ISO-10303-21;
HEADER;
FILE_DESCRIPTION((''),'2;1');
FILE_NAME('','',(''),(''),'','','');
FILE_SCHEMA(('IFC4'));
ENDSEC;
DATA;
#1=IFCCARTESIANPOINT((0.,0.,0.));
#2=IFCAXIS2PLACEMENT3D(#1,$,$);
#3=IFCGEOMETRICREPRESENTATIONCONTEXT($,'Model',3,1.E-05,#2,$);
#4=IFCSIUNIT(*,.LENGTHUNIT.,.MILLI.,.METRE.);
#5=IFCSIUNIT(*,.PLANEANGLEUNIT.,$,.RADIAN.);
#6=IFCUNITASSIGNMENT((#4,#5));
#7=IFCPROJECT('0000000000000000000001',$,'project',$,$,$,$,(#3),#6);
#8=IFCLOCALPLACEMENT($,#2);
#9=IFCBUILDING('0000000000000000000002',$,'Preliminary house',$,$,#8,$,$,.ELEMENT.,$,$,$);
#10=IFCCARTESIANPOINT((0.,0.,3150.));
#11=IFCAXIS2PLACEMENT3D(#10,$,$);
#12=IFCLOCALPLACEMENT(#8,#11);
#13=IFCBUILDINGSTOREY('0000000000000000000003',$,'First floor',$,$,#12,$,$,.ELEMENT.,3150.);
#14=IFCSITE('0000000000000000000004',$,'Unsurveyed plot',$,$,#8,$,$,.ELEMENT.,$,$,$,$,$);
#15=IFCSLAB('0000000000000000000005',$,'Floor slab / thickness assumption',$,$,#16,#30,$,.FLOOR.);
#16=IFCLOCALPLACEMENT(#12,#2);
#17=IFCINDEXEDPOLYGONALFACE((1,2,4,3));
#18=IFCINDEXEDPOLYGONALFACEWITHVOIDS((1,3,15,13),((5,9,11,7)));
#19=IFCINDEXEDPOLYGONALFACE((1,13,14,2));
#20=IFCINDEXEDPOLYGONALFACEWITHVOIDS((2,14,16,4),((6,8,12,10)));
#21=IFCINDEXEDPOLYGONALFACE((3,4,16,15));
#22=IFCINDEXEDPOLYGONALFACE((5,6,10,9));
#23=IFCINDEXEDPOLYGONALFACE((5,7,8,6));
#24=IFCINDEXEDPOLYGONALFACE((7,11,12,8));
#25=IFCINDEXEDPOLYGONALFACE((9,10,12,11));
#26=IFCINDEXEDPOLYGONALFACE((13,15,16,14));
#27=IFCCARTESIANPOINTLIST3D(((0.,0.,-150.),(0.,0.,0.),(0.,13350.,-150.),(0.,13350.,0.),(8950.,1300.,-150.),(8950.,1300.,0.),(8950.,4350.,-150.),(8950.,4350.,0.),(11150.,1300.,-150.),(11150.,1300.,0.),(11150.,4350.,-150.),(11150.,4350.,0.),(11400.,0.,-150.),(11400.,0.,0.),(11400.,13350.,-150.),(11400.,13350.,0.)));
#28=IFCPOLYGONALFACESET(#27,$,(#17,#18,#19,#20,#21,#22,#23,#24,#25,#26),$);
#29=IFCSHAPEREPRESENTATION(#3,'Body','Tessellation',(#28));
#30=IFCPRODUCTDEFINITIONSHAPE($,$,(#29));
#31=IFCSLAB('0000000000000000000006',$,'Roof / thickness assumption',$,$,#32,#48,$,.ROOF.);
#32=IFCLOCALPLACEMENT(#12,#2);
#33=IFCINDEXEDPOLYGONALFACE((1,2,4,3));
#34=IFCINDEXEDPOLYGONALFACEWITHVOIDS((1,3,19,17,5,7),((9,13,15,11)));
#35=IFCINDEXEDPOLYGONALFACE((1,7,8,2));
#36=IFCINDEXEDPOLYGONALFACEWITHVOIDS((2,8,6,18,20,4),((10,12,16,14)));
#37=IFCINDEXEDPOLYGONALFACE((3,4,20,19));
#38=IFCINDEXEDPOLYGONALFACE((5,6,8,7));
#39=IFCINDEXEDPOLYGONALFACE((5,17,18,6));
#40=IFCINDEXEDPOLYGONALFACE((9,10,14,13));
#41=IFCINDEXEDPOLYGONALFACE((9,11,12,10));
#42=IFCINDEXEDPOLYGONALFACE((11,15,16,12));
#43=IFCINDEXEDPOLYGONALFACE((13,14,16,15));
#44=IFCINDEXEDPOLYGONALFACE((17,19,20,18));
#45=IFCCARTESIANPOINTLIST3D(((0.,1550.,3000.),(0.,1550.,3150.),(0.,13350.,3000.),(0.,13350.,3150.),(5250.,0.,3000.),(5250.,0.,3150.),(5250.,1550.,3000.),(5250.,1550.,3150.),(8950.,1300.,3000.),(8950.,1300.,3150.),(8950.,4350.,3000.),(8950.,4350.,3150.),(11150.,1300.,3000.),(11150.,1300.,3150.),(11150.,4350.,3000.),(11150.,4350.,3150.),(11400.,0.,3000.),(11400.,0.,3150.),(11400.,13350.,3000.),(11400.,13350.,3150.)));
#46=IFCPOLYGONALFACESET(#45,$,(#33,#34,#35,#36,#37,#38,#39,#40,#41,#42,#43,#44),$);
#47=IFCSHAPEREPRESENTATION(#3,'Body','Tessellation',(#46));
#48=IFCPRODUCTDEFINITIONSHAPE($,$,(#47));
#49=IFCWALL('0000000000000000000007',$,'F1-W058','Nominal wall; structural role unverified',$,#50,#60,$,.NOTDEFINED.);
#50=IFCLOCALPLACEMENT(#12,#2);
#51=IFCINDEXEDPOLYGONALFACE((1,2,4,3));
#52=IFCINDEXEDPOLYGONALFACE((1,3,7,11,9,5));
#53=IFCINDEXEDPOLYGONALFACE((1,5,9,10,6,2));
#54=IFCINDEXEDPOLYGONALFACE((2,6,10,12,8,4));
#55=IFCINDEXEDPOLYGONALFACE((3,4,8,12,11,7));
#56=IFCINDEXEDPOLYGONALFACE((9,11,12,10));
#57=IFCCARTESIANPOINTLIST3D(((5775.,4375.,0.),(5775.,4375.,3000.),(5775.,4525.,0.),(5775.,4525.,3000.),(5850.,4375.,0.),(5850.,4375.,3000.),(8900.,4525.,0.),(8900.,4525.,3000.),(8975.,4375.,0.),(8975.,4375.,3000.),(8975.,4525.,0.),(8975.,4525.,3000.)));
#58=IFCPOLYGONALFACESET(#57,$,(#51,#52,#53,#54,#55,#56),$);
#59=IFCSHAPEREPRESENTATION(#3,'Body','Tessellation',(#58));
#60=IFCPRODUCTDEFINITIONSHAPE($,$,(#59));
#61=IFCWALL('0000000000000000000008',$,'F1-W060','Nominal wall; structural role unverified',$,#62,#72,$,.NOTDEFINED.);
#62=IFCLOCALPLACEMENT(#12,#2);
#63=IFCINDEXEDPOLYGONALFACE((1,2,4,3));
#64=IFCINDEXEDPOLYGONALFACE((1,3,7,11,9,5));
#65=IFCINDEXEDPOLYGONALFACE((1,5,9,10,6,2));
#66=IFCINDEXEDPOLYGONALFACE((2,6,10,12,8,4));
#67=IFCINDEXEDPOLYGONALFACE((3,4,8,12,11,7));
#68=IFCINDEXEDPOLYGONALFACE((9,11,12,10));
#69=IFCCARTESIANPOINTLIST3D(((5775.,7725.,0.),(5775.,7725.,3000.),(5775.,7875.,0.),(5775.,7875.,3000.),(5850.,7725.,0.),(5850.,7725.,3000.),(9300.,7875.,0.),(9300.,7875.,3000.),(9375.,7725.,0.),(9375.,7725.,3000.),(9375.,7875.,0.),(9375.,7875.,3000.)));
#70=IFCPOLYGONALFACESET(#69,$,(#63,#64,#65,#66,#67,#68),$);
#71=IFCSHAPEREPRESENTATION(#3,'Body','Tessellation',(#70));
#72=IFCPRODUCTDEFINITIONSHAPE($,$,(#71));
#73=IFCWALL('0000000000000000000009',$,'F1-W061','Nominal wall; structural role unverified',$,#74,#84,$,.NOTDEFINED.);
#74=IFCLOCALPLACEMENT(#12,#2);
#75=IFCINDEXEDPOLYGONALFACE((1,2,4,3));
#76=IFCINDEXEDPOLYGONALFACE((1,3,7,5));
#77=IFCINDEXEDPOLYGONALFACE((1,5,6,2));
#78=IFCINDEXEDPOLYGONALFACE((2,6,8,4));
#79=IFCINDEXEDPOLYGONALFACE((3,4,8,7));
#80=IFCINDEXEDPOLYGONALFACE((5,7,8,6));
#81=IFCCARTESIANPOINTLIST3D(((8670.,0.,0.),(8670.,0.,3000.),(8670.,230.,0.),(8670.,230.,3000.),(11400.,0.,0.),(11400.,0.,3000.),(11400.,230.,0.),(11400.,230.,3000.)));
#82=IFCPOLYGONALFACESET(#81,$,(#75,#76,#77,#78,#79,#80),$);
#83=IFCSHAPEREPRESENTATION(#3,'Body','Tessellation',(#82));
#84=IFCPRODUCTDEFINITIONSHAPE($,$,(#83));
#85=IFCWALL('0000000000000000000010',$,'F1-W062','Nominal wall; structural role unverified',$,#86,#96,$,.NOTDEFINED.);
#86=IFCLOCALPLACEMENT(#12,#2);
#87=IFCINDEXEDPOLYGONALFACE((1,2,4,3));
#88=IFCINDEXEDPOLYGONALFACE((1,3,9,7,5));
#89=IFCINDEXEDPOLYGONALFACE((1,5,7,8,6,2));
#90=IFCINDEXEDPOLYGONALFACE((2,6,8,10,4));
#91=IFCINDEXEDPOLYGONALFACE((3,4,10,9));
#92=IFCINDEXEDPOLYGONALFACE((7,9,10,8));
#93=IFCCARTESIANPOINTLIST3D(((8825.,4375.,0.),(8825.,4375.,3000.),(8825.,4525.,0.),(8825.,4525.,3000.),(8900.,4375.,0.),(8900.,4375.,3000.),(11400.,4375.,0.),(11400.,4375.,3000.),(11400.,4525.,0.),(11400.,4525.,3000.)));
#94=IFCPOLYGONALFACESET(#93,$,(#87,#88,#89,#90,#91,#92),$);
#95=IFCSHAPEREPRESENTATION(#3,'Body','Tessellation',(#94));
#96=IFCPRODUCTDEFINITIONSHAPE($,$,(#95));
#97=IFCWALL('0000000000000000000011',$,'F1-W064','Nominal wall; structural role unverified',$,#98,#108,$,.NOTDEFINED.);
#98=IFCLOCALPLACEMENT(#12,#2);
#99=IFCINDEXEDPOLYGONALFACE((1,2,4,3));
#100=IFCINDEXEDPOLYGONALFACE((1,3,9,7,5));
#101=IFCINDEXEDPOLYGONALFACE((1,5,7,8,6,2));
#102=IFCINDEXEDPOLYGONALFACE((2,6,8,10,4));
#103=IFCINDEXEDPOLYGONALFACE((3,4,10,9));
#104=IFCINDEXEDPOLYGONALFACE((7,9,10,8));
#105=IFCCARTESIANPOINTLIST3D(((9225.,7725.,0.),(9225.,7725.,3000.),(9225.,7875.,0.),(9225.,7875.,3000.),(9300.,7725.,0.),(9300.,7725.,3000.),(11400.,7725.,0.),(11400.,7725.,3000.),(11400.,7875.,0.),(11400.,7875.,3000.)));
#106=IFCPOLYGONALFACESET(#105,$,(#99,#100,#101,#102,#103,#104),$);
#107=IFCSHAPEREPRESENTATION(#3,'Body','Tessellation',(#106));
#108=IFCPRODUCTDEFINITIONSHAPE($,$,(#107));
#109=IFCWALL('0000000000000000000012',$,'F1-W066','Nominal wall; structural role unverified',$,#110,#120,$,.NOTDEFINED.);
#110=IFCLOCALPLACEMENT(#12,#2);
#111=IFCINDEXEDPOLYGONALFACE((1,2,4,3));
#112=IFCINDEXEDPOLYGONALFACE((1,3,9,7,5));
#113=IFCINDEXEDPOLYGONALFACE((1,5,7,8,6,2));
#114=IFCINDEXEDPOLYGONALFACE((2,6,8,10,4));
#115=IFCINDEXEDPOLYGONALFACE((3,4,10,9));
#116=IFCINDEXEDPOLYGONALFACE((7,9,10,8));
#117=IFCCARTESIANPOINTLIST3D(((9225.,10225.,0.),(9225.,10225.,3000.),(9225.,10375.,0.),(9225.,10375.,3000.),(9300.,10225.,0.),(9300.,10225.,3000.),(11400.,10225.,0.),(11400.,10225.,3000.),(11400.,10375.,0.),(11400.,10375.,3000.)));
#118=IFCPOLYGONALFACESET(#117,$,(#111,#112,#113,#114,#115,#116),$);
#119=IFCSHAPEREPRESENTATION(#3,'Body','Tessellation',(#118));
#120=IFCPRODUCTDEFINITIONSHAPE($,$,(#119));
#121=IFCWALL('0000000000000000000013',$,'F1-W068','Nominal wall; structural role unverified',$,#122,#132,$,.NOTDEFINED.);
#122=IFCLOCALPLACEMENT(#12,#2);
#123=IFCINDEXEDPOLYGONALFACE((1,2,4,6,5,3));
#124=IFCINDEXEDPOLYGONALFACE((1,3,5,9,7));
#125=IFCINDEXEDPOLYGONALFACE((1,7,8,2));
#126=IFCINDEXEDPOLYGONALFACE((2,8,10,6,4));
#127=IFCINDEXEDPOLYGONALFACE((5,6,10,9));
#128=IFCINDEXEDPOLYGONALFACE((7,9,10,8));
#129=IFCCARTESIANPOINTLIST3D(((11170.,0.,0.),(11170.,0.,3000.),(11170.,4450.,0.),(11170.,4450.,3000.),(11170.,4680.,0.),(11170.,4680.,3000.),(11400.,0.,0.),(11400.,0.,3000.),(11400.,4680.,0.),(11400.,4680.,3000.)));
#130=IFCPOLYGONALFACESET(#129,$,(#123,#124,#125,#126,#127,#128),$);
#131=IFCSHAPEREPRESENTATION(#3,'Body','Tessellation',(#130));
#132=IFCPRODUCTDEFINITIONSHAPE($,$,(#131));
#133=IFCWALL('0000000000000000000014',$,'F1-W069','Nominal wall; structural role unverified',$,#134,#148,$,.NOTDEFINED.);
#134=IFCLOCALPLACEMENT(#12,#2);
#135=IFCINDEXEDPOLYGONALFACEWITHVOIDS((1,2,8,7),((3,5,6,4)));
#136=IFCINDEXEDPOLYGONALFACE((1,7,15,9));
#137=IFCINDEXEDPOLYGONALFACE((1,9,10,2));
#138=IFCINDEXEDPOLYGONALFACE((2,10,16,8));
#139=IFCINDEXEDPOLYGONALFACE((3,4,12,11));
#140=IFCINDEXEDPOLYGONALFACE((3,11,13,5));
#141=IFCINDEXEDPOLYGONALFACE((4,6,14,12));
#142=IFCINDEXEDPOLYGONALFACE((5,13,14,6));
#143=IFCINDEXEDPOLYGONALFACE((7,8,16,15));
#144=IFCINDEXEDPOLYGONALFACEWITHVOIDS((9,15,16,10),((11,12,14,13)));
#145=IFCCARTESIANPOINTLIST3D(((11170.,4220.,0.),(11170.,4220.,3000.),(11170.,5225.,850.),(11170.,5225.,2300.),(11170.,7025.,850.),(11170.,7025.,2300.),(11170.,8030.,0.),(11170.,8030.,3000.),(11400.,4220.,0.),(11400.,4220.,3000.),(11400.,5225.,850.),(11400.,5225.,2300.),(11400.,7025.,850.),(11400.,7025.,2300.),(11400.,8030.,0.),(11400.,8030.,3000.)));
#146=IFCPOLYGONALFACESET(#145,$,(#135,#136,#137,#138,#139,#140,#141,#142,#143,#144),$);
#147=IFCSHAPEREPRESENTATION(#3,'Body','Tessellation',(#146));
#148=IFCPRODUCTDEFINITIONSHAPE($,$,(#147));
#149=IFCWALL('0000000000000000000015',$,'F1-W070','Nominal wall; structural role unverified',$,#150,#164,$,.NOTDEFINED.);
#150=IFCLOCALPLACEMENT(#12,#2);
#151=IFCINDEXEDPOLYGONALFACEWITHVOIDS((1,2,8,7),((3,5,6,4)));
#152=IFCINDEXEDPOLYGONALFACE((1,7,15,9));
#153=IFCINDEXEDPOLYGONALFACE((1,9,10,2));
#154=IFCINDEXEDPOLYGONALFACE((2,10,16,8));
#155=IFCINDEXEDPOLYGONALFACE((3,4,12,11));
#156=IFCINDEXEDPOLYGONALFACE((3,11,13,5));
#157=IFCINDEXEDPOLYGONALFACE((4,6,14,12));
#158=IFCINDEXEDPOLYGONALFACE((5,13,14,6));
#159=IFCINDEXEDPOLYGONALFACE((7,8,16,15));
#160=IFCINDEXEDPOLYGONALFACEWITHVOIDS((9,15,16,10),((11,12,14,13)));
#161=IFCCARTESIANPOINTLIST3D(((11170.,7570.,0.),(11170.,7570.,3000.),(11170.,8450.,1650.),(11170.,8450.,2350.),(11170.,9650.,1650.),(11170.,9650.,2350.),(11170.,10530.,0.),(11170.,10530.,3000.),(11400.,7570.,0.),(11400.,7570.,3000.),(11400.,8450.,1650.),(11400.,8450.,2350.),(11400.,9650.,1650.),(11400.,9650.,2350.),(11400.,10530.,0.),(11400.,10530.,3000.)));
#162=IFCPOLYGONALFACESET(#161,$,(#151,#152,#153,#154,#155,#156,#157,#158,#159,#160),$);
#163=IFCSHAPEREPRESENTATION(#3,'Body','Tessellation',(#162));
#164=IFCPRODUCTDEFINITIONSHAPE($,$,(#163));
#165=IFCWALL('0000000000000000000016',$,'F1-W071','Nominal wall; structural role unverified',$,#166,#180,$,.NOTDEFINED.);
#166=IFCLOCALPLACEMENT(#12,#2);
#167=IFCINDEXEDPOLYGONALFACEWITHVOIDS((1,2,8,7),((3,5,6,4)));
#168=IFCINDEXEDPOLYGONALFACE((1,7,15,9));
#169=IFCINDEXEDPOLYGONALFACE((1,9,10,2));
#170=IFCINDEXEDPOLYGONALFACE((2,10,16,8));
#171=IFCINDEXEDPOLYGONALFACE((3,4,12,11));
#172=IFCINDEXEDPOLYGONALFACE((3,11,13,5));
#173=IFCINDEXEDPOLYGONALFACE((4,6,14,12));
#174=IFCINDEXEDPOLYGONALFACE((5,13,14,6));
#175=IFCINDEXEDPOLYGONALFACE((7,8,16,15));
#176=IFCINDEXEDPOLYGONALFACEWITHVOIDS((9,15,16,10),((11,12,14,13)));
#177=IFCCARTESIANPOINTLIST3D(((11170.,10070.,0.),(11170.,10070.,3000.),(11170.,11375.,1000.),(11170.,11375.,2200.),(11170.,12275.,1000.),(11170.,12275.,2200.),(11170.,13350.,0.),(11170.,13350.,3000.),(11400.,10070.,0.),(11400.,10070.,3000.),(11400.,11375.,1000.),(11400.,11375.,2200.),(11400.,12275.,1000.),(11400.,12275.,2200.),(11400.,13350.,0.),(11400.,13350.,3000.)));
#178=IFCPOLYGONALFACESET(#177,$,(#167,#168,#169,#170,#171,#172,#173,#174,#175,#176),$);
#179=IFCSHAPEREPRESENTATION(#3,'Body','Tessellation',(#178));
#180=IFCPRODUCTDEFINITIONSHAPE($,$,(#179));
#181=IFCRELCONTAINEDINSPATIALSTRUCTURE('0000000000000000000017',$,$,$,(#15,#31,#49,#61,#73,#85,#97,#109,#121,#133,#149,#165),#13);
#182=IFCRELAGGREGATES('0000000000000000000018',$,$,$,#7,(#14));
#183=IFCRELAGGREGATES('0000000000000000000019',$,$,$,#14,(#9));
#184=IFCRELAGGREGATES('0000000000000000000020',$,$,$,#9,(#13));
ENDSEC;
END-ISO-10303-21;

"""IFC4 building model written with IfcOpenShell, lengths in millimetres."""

from ifc_helpers import new_model, si_unit, frame, origin, place, context, project, spatial, polyline, outline, extrude, element, save


model = new_model("IFC4")

# Units and contexts
model_context = context("Model", 3, precision=1e-05, world=origin())
ifc_project = project(units=[si_unit("LENGTHUNIT", "METRE", prefix="MILLI"), si_unit("PLANEANGLEUNIT", "RADIAN")], contexts=[model_context])

# Site, building, storey
placement_1 = place(None, origin())
site = spatial("IfcSite", under=ifc_project, at=placement_1, Name="Unsurveyed plot", CompositionType="ELEMENT")
building = spatial("IfcBuilding", under=site, at=placement_1, Name="Preliminary house", CompositionType="ELEMENT")
placement_2 = place(placement_1, frame((0.0, 0.0, 3150.0)))
storey = spatial("IfcBuildingStorey", under=building, at=placement_2, Name="First floor", CompositionType="ELEMENT", Elevation=3150.0)

# Slabs
element("IfcSlab", 1, at=placement_2, inside=storey, Name="Floor slab / thickness assumption", PredefinedType="FLOOR", context=model_context, shape_type="SweptSolid", body=[
    extrude(outline(polyline([(0.0, 0.0), (0.0, 13350.0), (11400.0, 13350.0), (11400.0, 0.0), (0.0, 0.0)]), holes=[polyline([(11150.0, 4350.0), (8950.0, 4350.0), (8950.0, 1300.0), (11150.0, 1300.0), (11150.0, 4350.0)])]), frame((0.0, 0.0, -150.0)), (0.0, 0.0, 1.0), 150.0),
])
element("IfcSlab", 2, at=placement_2, inside=storey, Name="Roof / thickness assumption", PredefinedType="ROOF", context=model_context, shape_type="SweptSolid", body=[
    extrude(outline(polyline([(11400.0, 13350.0), (11400.0, 0.0), (5250.0, 0.0), (5250.0, 1550.0), (0.0, 1550.0), (0.0, 13350.0), (11400.0, 13350.0)]), holes=[polyline([(11150.0, 4350.0), (8950.0, 4350.0), (8950.0, 1300.0), (11150.0, 1300.0), (11150.0, 4350.0)])]), frame((0.0, 0.0, 3000.0)), (0.0, 0.0, 1.0), 150.0),
])

# Wall
element("IfcWall", 3, at=placement_2, inside=storey, Name="F1-W058", Description="Nominal wall; structural role unverified", PredefinedType="NOTDEFINED", context=model_context, shape_type="SweptSolid", body=[
    extrude(outline(polyline([(8975.0, 4525.0), (8975.0, 4375.0), (5850.0, 4375.0), (5775.0, 4375.0), (5775.0, 4525.0), (8900.0, 4525.0), (8975.0, 4525.0)])), origin(), (0.0, 0.0, 1.0), 3000.0),
])

# Walls
element("IfcWall", 4, at=placement_2, inside=storey, Name="F1-W060", Description="Nominal wall; structural role unverified", PredefinedType="NOTDEFINED", context=model_context, shape_type="SweptSolid", body=[
    extrude(outline(polyline([(9375.0, 7875.0), (9375.0, 7725.0), (5850.0, 7725.0), (5775.0, 7725.0), (5775.0, 7875.0), (9300.0, 7875.0), (9375.0, 7875.0)])), origin(), (0.0, 0.0, 1.0), 3000.0),
])
element("IfcWall", 5, at=placement_2, inside=storey, Name="F1-W061", Description="Nominal wall; structural role unverified", PredefinedType="NOTDEFINED", context=model_context, shape_type="SweptSolid", body=[
    extrude(outline(polyline([(8670.0, 230.0), (11400.0, 230.0), (11400.0, 0.0), (8670.0, 0.0), (8670.0, 230.0)])), origin(), (0.0, 0.0, 1.0), 3000.0),
])
element("IfcWall", 6, at=placement_2, inside=storey, Name="F1-W062", Description="Nominal wall; structural role unverified", PredefinedType="NOTDEFINED", context=model_context, shape_type="SweptSolid", body=[
    extrude(outline(polyline([(8900.0, 4375.0), (8825.0, 4375.0), (8825.0, 4525.0), (11400.0, 4525.0), (11400.0, 4375.0), (8900.0, 4375.0)])), origin(), (0.0, 0.0, 1.0), 3000.0),
])

# Wall
element("IfcWall", 7, at=placement_2, inside=storey, Name="F1-W064", Description="Nominal wall; structural role unverified", PredefinedType="NOTDEFINED", context=model_context, shape_type="SweptSolid", body=[
    extrude(outline(polyline([(9300.0, 7725.0), (9225.0, 7725.0), (9225.0, 7875.0), (11400.0, 7875.0), (11400.0, 7725.0), (9300.0, 7725.0)])), origin(), (0.0, 0.0, 1.0), 3000.0),
])

# Wall
element("IfcWall", 8, at=placement_2, inside=storey, Name="F1-W066", Description="Nominal wall; structural role unverified", PredefinedType="NOTDEFINED", context=model_context, shape_type="SweptSolid", body=[
    extrude(outline(polyline([(9300.0, 10225.0), (9225.0, 10225.0), (9225.0, 10375.0), (11400.0, 10375.0), (11400.0, 10225.0), (9300.0, 10225.0)])), origin(), (0.0, 0.0, 1.0), 3000.0),
])

# Wall
element("IfcWall", 9, at=placement_2, inside=storey, Name="F1-W068", Description="Nominal wall; structural role unverified", PredefinedType="NOTDEFINED", context=model_context, shape_type="SweptSolid", body=[
    extrude(outline(polyline([(11170.0, 4680.0), (11400.0, 4680.0), (11400.0, 0.0), (11170.0, 0.0), (11170.0, 4450.0), (11170.0, 4680.0)])), origin(), (0.0, 0.0, 1.0), 3000.0),
])

# Walls, openings
wall_1 = element("IfcWall", 10, at=placement_2, inside=storey, Name="F1-W069", Description="Nominal wall; structural role unverified", PredefinedType="NOTDEFINED", context=model_context, shape_type="SweptSolid", body=[
    extrude(outline(polyline([(11170.0, 8030.0), (11400.0, 8030.0), (11400.0, 4220.0), (11170.0, 4220.0), (11170.0, 7800.0), (11170.0, 8030.0)])), origin(), (0.0, 0.0, 1.0), 3000.0),
])
element("IfcOpeningElement", 11, at=placement_2, cuts=wall_1, PredefinedType="OPENING", context=model_context, shape_type="SweptSolid", body=[
    extrude(outline(polyline([(11815.0, 5225.0), (11815.0, 7025.0), (10755.0, 7025.0), (10755.0, 5225.0), (11815.0, 5225.0)])), frame((0.0, 0.0, 850.0)), (0.0, 0.0, 1.0), 1450.0),
])
wall_2 = element("IfcWall", 12, at=placement_2, inside=storey, Name="F1-W070", Description="Nominal wall; structural role unverified", PredefinedType="NOTDEFINED", context=model_context, shape_type="SweptSolid", body=[
    extrude(outline(polyline([(11170.0, 10530.0), (11400.0, 10530.0), (11400.0, 7570.0), (11170.0, 7570.0), (11170.0, 10300.0), (11170.0, 10530.0)])), origin(), (0.0, 0.0, 1.0), 3000.0),
])
element("IfcOpeningElement", 13, at=placement_2, cuts=wall_2, PredefinedType="OPENING", context=model_context, shape_type="SweptSolid", body=[
    extrude(outline(polyline([(11815.0, 8450.0), (11815.0, 9650.0), (10755.0, 9650.0), (10755.0, 8450.0), (11815.0, 8450.0)])), frame((0.0, 0.0, 1650.0)), (0.0, 0.0, 1.0), 700.0),
])
wall_3 = element("IfcWall", 14, at=placement_2, inside=storey, Name="F1-W071", Description="Nominal wall; structural role unverified", PredefinedType="NOTDEFINED", context=model_context, shape_type="SweptSolid", body=[
    extrude(outline(polyline([(11170.0, 10070.0), (11170.0, 13350.0), (11400.0, 13350.0), (11400.0, 10070.0), (11170.0, 10070.0)])), origin(), (0.0, 0.0, 1.0), 3000.0),
])
element("IfcOpeningElement", 15, at=placement_2, cuts=wall_3, PredefinedType="OPENING", context=model_context, shape_type="SweptSolid", body=[
    extrude(outline(polyline([(11815.0, 11375.0), (11815.0, 12275.0), (10755.0, 12275.0), (10755.0, 11375.0), (11815.0, 11375.0)])), frame((0.0, 0.0, 1000.0)), (0.0, 0.0, 1.0), 1200.0),
])

save(model, "model.ifc")
